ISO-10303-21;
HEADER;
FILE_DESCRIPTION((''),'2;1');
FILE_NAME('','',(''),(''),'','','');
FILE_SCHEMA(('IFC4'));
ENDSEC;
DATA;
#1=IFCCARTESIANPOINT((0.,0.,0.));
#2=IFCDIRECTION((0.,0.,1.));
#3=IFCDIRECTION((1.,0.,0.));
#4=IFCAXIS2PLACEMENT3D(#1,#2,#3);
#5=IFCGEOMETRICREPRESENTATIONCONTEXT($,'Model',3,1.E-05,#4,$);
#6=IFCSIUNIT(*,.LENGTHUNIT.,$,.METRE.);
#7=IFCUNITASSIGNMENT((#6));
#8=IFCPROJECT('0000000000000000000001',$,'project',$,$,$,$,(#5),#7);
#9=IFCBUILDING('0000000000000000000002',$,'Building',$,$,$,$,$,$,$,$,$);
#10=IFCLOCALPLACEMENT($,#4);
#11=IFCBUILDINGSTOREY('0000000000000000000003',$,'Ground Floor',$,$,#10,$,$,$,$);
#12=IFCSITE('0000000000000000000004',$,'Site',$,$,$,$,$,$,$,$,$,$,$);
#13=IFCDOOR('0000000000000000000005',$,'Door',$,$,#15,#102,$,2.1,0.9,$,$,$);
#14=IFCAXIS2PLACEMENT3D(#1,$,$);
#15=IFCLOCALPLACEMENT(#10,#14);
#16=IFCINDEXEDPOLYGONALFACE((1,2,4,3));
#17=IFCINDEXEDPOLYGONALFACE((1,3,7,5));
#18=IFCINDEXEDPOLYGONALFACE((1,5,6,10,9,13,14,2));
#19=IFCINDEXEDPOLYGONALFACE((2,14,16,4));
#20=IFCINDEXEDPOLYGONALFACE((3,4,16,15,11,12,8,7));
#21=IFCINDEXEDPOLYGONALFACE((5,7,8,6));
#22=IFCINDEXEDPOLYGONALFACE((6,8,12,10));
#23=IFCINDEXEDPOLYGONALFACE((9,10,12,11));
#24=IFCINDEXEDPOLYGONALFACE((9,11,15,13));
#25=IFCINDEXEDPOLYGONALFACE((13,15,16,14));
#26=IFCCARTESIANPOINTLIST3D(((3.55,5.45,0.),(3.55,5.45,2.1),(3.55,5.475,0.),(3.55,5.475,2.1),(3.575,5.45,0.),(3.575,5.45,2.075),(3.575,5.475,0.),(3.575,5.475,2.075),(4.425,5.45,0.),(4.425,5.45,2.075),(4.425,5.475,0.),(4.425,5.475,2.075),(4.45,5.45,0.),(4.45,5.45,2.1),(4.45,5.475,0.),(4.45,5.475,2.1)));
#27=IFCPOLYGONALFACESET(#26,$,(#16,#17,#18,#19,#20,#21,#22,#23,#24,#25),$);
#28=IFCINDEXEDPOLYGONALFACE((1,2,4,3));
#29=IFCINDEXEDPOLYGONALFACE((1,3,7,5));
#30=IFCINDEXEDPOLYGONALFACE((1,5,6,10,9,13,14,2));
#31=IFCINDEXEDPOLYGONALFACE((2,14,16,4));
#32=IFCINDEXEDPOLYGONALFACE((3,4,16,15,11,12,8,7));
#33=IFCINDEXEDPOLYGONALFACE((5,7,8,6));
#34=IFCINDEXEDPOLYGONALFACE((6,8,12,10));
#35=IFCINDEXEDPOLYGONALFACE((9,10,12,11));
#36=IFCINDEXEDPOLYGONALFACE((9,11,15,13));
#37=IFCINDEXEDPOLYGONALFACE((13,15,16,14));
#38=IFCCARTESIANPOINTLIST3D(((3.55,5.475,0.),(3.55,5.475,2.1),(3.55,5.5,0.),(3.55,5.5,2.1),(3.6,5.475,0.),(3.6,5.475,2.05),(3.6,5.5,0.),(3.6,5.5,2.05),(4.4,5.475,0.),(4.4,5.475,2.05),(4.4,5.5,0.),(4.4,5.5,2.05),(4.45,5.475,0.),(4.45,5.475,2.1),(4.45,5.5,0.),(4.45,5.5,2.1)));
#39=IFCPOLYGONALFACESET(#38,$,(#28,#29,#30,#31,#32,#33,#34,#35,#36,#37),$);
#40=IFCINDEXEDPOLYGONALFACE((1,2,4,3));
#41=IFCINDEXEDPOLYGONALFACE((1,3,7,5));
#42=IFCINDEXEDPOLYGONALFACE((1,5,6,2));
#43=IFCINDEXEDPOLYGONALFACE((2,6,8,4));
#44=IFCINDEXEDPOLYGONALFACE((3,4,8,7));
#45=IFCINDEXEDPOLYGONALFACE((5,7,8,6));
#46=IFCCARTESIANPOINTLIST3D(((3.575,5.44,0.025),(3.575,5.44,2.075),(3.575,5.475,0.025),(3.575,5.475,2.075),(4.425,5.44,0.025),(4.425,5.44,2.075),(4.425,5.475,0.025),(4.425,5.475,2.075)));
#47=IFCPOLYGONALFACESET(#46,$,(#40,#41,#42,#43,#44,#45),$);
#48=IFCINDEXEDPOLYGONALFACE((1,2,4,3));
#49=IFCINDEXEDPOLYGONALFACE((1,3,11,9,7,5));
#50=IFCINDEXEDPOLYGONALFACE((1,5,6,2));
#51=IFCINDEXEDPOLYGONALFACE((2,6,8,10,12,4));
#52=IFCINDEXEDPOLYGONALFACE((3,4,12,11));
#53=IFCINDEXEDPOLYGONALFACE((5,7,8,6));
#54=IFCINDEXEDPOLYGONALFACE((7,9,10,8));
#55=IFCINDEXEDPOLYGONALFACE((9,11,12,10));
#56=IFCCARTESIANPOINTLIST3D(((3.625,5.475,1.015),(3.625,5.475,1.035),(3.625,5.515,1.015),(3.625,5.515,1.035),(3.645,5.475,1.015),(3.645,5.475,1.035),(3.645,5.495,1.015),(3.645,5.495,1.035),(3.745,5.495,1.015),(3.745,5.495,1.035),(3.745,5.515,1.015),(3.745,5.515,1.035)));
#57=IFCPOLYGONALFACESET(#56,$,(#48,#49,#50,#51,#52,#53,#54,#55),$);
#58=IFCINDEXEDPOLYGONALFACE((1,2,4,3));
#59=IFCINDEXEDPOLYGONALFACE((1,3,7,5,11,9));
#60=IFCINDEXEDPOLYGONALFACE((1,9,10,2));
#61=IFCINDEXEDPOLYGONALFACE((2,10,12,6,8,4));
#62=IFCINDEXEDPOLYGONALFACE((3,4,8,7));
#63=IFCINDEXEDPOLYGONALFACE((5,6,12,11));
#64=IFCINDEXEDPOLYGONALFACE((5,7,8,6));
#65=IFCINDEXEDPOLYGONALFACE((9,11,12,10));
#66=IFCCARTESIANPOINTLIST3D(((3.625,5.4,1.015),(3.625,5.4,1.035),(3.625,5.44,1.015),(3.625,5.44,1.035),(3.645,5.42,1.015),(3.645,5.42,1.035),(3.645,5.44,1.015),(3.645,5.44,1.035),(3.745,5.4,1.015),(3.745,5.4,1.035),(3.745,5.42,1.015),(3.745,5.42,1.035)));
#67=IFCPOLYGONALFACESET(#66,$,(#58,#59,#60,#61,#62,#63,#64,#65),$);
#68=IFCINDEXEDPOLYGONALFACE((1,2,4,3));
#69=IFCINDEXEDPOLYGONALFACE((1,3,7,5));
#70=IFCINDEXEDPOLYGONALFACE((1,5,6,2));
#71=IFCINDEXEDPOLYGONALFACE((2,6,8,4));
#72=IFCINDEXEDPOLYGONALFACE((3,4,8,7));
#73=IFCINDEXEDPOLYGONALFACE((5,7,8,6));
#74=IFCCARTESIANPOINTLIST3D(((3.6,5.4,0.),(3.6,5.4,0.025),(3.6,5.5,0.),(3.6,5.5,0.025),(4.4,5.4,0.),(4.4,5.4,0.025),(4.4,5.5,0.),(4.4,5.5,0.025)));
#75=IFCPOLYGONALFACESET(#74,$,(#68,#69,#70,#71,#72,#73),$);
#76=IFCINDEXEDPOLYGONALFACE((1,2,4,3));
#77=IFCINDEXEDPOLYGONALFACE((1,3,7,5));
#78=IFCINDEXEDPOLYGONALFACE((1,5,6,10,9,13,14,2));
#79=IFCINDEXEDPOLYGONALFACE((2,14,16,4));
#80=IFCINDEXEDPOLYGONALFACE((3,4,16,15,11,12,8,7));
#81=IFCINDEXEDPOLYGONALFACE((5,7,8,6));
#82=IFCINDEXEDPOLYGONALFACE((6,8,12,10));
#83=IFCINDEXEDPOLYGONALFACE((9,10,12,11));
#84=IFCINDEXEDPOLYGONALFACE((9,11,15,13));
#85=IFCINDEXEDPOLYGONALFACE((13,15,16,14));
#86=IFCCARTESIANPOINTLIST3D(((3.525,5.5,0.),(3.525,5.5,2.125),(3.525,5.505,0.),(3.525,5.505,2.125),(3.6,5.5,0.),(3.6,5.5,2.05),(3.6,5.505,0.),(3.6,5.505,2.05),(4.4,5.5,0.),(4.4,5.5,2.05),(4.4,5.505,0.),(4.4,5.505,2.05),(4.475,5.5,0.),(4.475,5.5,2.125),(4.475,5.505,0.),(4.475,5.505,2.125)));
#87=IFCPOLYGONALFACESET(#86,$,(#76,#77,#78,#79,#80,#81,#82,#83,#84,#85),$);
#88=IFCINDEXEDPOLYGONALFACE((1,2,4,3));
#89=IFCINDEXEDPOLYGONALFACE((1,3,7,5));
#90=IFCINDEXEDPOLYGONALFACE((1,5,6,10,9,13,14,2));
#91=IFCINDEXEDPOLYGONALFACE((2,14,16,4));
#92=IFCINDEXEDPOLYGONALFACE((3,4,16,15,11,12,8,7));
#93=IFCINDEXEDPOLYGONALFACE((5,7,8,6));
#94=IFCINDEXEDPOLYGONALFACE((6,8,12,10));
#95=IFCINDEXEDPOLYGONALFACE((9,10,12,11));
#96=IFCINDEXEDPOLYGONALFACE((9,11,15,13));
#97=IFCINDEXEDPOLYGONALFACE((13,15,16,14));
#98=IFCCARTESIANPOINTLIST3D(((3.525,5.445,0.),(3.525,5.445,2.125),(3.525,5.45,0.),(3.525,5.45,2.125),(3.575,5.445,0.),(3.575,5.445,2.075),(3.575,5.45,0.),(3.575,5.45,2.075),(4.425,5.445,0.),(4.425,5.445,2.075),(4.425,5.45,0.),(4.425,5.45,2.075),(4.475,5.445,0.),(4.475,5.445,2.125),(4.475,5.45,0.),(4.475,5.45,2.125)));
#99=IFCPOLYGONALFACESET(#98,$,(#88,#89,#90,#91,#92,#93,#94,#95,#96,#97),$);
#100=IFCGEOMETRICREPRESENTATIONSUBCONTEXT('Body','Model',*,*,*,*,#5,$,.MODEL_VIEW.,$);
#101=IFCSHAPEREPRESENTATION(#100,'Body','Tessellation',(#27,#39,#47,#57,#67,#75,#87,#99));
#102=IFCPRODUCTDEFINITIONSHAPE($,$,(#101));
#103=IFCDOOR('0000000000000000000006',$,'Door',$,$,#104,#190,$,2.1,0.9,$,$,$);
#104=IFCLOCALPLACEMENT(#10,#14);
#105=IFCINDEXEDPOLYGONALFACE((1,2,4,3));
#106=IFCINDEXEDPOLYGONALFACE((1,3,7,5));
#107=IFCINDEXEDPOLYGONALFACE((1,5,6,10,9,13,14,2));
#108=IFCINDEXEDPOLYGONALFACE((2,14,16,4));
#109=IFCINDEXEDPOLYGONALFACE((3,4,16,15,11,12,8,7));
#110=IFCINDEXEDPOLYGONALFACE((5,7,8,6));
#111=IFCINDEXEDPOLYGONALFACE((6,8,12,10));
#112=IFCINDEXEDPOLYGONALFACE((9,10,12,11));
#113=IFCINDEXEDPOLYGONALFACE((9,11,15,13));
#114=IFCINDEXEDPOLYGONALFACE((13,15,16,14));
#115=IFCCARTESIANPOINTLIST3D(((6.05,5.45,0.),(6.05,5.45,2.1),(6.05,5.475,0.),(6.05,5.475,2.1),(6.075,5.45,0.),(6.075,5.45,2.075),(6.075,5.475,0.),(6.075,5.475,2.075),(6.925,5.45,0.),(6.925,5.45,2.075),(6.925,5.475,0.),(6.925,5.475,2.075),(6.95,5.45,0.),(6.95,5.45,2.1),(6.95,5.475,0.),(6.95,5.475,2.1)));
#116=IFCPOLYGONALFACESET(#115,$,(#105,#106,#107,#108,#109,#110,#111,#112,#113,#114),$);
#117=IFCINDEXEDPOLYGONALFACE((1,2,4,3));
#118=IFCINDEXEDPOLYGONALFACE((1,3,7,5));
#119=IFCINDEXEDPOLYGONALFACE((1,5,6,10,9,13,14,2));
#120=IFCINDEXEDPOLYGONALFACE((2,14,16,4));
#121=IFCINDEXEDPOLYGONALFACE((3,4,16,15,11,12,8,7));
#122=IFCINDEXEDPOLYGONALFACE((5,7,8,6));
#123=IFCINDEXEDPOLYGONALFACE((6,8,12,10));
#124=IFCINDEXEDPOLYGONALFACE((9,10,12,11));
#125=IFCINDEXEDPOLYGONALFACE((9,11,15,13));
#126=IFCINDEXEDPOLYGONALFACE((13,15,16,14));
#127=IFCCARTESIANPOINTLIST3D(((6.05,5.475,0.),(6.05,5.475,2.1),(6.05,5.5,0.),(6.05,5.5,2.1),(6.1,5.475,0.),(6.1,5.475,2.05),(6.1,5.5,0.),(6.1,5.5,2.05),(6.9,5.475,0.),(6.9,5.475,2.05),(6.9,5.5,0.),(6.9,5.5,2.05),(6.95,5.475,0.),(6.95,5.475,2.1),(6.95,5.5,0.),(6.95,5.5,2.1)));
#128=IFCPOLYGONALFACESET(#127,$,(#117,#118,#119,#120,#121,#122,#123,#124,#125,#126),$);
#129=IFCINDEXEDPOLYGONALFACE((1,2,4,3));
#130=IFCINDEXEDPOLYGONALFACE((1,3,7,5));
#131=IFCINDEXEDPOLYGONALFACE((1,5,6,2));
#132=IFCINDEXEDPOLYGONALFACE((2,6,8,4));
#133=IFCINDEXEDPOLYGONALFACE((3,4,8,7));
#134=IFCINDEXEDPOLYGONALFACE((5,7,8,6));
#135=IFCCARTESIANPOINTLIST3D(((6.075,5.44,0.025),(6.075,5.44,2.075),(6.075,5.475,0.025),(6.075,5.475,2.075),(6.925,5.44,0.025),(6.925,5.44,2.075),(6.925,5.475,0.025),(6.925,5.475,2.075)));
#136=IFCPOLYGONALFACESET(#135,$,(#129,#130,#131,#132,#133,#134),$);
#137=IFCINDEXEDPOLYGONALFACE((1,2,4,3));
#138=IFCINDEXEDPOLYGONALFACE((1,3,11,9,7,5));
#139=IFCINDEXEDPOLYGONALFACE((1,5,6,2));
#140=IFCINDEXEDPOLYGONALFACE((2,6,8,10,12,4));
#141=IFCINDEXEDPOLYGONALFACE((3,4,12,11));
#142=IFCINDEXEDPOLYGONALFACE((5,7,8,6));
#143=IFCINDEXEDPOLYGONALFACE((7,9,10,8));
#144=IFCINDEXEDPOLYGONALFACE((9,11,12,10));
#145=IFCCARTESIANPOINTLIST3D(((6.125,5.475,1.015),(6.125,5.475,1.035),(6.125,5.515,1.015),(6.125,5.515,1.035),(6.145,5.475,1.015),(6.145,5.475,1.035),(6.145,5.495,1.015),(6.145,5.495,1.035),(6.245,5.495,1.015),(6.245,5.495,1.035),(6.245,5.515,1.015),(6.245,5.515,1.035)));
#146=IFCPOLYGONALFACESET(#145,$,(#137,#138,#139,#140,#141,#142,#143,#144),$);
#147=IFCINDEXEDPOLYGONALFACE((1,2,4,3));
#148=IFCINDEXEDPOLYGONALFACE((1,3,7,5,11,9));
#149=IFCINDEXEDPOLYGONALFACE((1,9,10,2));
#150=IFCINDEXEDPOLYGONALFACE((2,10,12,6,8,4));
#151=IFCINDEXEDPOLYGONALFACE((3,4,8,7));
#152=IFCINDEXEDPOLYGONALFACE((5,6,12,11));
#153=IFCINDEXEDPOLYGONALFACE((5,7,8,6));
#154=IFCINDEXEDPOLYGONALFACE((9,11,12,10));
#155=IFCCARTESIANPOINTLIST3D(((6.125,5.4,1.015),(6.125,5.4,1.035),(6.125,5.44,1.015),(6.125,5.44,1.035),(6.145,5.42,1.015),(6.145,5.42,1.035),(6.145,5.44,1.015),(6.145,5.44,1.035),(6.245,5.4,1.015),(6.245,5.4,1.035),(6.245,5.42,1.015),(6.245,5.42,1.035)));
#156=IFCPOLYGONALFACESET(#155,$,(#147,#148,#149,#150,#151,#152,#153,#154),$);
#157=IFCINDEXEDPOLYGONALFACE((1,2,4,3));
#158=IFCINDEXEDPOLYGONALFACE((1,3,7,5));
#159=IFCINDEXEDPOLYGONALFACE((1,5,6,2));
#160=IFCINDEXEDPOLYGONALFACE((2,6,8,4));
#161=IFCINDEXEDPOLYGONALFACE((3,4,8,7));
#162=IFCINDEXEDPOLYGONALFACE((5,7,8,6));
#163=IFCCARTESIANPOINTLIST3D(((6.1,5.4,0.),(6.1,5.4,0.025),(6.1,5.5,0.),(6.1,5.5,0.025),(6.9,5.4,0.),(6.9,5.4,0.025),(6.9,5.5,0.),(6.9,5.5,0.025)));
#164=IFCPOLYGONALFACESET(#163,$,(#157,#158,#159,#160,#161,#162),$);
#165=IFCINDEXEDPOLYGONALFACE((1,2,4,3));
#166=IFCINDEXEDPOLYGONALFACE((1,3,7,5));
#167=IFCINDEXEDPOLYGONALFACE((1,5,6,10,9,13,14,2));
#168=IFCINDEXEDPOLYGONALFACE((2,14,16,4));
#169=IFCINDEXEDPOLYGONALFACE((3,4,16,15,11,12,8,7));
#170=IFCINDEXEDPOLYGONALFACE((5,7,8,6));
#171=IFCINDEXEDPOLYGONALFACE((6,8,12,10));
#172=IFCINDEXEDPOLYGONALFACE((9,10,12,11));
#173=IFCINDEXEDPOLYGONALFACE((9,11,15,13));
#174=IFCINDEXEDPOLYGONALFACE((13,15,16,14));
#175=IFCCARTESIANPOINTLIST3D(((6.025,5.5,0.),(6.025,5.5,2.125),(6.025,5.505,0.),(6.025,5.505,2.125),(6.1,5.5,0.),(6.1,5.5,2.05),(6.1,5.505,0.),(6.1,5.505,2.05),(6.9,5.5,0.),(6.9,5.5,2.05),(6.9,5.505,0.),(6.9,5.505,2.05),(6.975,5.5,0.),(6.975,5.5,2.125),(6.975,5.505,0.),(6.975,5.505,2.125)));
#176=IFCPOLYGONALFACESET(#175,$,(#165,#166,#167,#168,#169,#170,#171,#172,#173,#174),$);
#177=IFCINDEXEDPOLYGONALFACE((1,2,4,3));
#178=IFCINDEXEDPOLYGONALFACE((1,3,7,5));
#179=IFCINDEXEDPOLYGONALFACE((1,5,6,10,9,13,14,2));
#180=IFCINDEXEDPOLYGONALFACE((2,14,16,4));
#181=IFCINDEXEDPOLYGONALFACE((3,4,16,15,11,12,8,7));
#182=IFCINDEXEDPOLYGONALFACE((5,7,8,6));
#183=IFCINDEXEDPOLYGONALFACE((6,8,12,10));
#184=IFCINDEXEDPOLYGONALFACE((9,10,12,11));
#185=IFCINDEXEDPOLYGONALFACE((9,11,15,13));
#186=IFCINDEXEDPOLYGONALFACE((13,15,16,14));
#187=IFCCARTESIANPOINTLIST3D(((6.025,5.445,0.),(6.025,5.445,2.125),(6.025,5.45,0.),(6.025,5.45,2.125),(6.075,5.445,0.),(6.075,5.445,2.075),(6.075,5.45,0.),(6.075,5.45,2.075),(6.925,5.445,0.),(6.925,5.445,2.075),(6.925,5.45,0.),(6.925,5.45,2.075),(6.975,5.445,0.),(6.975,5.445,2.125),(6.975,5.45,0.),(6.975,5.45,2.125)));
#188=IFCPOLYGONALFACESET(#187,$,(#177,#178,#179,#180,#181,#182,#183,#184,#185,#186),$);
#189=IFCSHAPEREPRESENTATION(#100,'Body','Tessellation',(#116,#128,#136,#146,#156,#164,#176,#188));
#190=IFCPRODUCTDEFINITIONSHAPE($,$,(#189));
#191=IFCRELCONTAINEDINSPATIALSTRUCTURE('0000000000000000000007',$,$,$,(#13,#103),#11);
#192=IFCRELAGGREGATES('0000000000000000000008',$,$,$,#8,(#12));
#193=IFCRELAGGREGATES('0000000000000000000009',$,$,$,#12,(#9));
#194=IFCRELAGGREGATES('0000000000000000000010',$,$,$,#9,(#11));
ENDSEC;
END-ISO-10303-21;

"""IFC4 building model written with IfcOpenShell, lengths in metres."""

from ifc_helpers import new_model, si_unit, frame, origin_with_axes, place, context, subcontext, project, spatial, line, indexed_curve, outline, extrude, element, save


model = new_model("IFC4")

# Units and contexts
model_context = context("Model", 3, precision=1e-05, world=origin_with_axes())
body_context = subcontext(model_context, "Body", "Model", "MODEL_VIEW")
ifc_project = project(units=[si_unit("LENGTHUNIT", "METRE")], contexts=[model_context])

# Site, building, storey
site = spatial("IfcSite", under=ifc_project, Name="Site")
building = spatial("IfcBuilding", under=site, Name="Building")
storey_placement = place(None, origin_with_axes())
storey = spatial("IfcBuildingStorey", under=building, at=storey_placement, Name="Ground Floor")

# Doors
door_1_placement = place(storey_placement, frame((4.45, 5.5, 0.0), z_axis=(0.0, 0.0, 1.0), x_axis=(-1.0, 0.0, 0.0)))
element("IfcDoor", 1, at=door_1_placement, inside=storey, Name="Door", OverallHeight=2.1, OverallWidth=0.9, context=body_context, shape_type="SweptSolid", body=[
    extrude(outline(indexed_curve([(0.0, 0.0), (0.0, 2.1), (0.9, 2.1), (0.9, 0.0), (0.875, 0.0), (0.875, 2.075), (0.025, 2.075), (0.025, 0.0)], segments=[line(1, 2, 3, 4, 5, 6, 7, 8, 1)])), frame((0.0, 0.025, 0.0), z_axis=(0.0, -1.0, 0.0), x_axis=(1.0, 0.0, 0.0)), (0.0, 0.0, -1.0), 0.025),
    extrude(outline(indexed_curve([(0.0, 0.0), (0.0, 2.1), (0.9, 2.1), (0.9, 0.0), (0.85, 0.0), (0.85, 2.05), (0.05, 2.05), (0.05, 0.0)], segments=[line(1, 2, 3, 4, 5, 6, 7, 8, 1)])), frame((0.0, 0.0, 0.0), z_axis=(0.0, -1.0, 0.0), x_axis=(1.0, 0.0, 0.0)), (0.0, 0.0, -1.0), 0.025),
    extrude(outline(indexed_curve([(0.0, 0.0), (0.85, 0.0), (0.85, 0.035), (0.0, 0.035)], segments=[line(1, 2, 3, 4, 1)])), frame((0.025, 0.025, 0.025), z_axis=(0.0, 0.0, 1.0), x_axis=(1.0, 0.0, 0.0)), (0.0, 0.0, 1.0), 2.05),
    extrude(outline(indexed_curve([(0.0, 0.0), (0.0, -0.04), (-0.12, -0.04), (-0.12, -0.02), (-0.02, -0.02), (-0.02, 0.0)], segments=[line(1, 2, 3, 4, 5, 6, 1)])), frame((0.825, 0.025, 1.015), z_axis=(0.0, 0.0, 1.0), x_axis=(1.0, 0.0, 0.0)), (0.0, 0.0, 1.0), 0.02),
    extrude(outline(indexed_curve([(0.0, 0.0), (0.0, 0.04), (-0.12, 0.04), (-0.12, 0.02), (-0.02, 0.02), (-0.02, 0.0)], segments=[line(1, 2, 3, 4, 5, 6, 1)])), frame((0.825, 0.06, 1.015), z_axis=(0.0, 0.0, 1.0), x_axis=(1.0, 0.0, 0.0)), (0.0, 0.0, 1.0), 0.02),
    extrude(outline(indexed_curve([(0.0, 0.0), (0.8, 0.0), (0.8, 0.1), (0.0, 0.1)], segments=[line(1, 2, 3, 4, 1)])), frame((0.05, 0.0, 0.0), z_axis=(0.0, 0.0, 1.0), x_axis=(1.0, 0.0, 0.0)), (0.0, 0.0, 1.0), 0.025),
    extrude(outline(indexed_curve([(0.0, 0.0), (0.0, 2.125), (0.95, 2.125), (0.95, 0.0), (0.875, 0.0), (0.875, 2.05), (0.075, 2.05), (0.075, 0.0)], segments=[line(1, 2, 3, 4, 5, 6, 7, 8, 1)])), frame((-0.025, -0.005, 0.0), z_axis=(0.0, -1.0, 0.0), x_axis=(1.0, 0.0, 0.0)), (0.0, 0.0, -1.0), 0.005),
    extrude(outline(indexed_curve([(0.0, 0.0), (0.0, 2.125), (0.95, 2.125), (0.95, 0.0), (0.9, 0.0), (0.9, 2.075), (0.05, 2.075), (0.05, 0.0)], segments=[line(1, 2, 3, 4, 5, 6, 7, 8, 1)])), frame((-0.025, 0.05, 0.0), z_axis=(0.0, -1.0, 0.0), x_axis=(1.0, 0.0, 0.0)), (0.0, 0.0, -1.0), 0.005),
])
door_2_placement = place(storey_placement, frame((6.95, 5.5, 0.0), z_axis=(0.0, 0.0, 1.0), x_axis=(-1.0, 0.0, 0.0)))
element("IfcDoor", 2, at=door_2_placement, inside=storey, Name="Door", OverallHeight=2.1, OverallWidth=0.9, context=body_context, shape_type="SweptSolid", body=[
    extrude(outline(indexed_curve([(0.0, 0.0), (0.0, 2.1), (0.9, 2.1), (0.9, 0.0), (0.875, 0.0), (0.875, 2.075), (0.025, 2.075), (0.025, 0.0)], segments=[line(1, 2, 3, 4, 5, 6, 7, 8, 1)])), frame((0.0, 0.025, 0.0), z_axis=(0.0, -1.0, 0.0), x_axis=(1.0, 0.0, 0.0)), (0.0, 0.0, -1.0), 0.025),
    extrude(outline(indexed_curve([(0.0, 0.0), (0.0, 2.1), (0.9, 2.1), (0.9, 0.0), (0.85, 0.0), (0.85, 2.05), (0.05, 2.05), (0.05, 0.0)], segments=[line(1, 2, 3, 4, 5, 6, 7, 8, 1)])), frame((0.0, 0.0, 0.0), z_axis=(0.0, -1.0, 0.0), x_axis=(1.0, 0.0, 0.0)), (0.0, 0.0, -1.0), 0.025),
    extrude(outline(indexed_curve([(0.0, 0.0), (0.85, 0.0), (0.85, 0.035), (0.0, 0.035)], segments=[line(1, 2, 3, 4, 1)])), frame((0.025, 0.025, 0.025), z_axis=(0.0, 0.0, 1.0), x_axis=(1.0, 0.0, 0.0)), (0.0, 0.0, 1.0), 2.05),
    extrude(outline(indexed_curve([(0.0, 0.0), (0.0, -0.04), (-0.12, -0.04), (-0.12, -0.02), (-0.02, -0.02), (-0.02, 0.0)], segments=[line(1, 2, 3, 4, 5, 6, 1)])), frame((0.825, 0.025, 1.015), z_axis=(0.0, 0.0, 1.0), x_axis=(1.0, 0.0, 0.0)), (0.0, 0.0, 1.0), 0.02),
    extrude(outline(indexed_curve([(0.0, 0.0), (0.0, 0.04), (-0.12, 0.04), (-0.12, 0.02), (-0.02, 0.02), (-0.02, 0.0)], segments=[line(1, 2, 3, 4, 5, 6, 1)])), frame((0.825, 0.06, 1.015), z_axis=(0.0, 0.0, 1.0), x_axis=(1.0, 0.0, 0.0)), (0.0, 0.0, 1.0), 0.02),
    extrude(outline(indexed_curve([(0.0, 0.0), (0.8, 0.0), (0.8, 0.1), (0.0, 0.1)], segments=[line(1, 2, 3, 4, 1)])), frame((0.05, 0.0, 0.0), z_axis=(0.0, 0.0, 1.0), x_axis=(1.0, 0.0, 0.0)), (0.0, 0.0, 1.0), 0.025),
    extrude(outline(indexed_curve([(0.0, 0.0), (0.0, 2.125), (0.95, 2.125), (0.95, 0.0), (0.875, 0.0), (0.875, 2.05), (0.075, 2.05), (0.075, 0.0)], segments=[line(1, 2, 3, 4, 5, 6, 7, 8, 1)])), frame((-0.025, -0.005, 0.0), z_axis=(0.0, -1.0, 0.0), x_axis=(1.0, 0.0, 0.0)), (0.0, 0.0, -1.0), 0.005),
    extrude(outline(indexed_curve([(0.0, 0.0), (0.0, 2.125), (0.95, 2.125), (0.95, 0.0), (0.9, 0.0), (0.9, 2.075), (0.05, 2.075), (0.05, 0.0)], segments=[line(1, 2, 3, 4, 5, 6, 7, 8, 1)])), frame((-0.025, 0.05, 0.0), z_axis=(0.0, -1.0, 0.0), x_axis=(1.0, 0.0, 0.0)), (0.0, 0.0, -1.0), 0.005),
])

save(model, "model.ifc")
